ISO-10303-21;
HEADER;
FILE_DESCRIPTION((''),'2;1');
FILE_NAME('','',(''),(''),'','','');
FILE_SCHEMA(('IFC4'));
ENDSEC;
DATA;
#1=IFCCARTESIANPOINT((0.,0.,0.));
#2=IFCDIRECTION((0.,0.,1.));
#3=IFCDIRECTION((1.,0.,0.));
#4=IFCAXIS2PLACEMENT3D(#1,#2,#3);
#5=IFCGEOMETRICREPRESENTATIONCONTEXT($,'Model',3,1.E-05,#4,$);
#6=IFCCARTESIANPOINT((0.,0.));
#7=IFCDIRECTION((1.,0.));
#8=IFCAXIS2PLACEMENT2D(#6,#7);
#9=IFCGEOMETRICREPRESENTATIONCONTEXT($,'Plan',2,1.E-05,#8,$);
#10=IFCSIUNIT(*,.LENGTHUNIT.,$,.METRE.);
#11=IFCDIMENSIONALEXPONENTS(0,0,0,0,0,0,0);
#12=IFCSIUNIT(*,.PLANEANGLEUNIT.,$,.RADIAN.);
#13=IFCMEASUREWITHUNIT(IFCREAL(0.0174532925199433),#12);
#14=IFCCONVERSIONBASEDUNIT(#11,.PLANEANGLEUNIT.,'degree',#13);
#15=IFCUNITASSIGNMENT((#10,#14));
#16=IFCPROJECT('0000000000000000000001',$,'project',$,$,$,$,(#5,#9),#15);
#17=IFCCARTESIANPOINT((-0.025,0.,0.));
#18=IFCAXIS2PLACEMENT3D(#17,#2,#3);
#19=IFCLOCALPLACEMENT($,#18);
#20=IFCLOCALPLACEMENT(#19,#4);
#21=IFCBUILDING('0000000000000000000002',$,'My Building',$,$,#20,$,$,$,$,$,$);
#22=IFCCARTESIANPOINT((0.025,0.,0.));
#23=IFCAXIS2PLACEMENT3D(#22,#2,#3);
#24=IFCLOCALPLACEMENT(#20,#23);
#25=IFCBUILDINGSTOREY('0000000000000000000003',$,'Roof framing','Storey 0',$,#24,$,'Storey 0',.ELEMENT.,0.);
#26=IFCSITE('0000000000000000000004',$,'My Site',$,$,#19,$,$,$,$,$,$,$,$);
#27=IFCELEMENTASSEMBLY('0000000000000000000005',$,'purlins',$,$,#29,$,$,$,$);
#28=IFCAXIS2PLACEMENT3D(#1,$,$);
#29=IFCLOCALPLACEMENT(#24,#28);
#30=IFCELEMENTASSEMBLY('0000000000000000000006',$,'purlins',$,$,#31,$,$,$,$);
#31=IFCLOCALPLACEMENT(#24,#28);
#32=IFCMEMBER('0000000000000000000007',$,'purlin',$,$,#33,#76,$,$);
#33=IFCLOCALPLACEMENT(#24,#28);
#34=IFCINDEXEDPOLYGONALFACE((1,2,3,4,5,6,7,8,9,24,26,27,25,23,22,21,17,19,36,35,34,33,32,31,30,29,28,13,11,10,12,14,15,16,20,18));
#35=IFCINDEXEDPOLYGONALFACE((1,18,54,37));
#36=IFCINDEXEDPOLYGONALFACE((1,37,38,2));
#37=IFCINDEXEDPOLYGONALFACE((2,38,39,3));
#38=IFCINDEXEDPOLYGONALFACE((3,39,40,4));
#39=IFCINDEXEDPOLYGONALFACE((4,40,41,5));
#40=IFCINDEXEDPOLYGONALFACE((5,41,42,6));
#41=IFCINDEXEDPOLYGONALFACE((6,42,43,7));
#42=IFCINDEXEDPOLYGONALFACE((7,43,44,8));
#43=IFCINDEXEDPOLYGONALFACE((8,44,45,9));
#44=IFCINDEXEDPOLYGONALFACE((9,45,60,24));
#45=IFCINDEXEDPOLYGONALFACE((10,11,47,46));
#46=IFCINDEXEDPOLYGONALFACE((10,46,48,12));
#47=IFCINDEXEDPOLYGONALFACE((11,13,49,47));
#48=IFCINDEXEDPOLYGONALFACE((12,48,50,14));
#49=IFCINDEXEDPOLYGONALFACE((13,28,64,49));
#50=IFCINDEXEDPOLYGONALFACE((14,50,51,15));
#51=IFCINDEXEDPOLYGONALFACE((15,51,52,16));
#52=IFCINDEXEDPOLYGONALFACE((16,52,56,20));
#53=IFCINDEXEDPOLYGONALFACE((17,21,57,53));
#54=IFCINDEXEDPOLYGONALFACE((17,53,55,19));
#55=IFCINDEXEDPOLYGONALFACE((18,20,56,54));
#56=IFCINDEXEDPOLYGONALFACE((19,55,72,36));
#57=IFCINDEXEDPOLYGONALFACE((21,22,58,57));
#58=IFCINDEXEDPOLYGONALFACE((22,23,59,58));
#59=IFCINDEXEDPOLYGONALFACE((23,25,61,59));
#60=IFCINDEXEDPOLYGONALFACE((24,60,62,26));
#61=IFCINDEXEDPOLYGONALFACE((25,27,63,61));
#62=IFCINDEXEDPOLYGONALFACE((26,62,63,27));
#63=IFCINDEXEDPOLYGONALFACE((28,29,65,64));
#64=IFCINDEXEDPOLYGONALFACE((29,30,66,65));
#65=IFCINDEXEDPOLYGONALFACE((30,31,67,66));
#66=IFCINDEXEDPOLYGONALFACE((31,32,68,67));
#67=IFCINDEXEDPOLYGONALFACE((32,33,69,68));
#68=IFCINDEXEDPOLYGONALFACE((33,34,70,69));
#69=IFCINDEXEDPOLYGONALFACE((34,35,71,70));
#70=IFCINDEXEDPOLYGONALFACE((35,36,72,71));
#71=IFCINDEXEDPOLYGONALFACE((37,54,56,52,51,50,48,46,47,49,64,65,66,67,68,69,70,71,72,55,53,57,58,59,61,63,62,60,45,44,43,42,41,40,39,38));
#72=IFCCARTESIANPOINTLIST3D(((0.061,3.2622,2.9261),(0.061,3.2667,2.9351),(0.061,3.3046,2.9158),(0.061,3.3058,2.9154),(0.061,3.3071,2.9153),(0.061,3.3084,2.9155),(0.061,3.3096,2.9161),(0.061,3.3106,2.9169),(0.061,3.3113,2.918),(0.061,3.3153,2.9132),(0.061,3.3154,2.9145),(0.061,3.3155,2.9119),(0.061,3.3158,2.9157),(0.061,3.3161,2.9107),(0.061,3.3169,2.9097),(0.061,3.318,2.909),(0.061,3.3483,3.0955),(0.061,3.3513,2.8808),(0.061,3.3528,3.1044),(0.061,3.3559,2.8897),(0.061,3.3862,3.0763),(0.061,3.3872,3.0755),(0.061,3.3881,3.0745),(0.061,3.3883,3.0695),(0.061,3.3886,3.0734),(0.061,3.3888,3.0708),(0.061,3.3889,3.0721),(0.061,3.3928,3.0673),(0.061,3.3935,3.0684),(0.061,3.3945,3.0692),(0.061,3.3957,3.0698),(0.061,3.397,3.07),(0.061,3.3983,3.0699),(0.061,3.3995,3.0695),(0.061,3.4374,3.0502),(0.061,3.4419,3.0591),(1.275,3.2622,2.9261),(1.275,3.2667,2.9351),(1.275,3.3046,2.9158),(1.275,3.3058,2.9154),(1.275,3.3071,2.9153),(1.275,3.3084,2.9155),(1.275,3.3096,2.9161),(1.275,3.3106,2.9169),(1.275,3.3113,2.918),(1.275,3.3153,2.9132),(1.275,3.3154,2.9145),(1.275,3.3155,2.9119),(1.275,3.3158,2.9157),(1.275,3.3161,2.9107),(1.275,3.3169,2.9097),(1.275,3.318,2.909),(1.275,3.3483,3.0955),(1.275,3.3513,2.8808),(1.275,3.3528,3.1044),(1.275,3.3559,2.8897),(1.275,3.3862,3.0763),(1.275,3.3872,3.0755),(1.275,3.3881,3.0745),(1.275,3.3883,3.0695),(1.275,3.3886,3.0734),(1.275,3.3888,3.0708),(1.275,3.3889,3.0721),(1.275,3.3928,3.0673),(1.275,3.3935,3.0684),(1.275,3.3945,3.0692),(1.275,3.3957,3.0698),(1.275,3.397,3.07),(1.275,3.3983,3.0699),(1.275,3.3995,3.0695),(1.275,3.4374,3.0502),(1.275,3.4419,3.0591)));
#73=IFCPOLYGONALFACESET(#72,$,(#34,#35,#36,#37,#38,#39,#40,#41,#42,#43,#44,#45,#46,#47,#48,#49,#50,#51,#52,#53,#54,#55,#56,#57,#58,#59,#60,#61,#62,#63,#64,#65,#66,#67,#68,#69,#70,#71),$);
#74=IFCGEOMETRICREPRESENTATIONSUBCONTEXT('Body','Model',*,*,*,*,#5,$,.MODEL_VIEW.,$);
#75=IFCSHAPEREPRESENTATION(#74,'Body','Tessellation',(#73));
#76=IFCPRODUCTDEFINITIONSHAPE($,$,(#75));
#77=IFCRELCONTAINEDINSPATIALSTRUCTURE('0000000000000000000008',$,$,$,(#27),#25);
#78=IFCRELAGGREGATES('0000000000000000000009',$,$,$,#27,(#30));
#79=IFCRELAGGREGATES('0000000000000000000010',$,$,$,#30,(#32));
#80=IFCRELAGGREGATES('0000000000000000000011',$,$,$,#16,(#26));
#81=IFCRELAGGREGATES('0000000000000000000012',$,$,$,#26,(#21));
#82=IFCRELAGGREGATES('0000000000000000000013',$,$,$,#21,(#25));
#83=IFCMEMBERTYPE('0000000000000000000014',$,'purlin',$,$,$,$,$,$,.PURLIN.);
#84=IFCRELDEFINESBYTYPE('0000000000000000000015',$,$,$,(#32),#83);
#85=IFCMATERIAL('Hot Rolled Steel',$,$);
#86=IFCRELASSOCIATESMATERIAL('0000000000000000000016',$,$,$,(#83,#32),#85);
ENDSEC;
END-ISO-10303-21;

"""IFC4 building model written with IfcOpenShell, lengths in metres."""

from ifc_helpers import new_model, entity, si_unit, converted_unit, frame, frame_2d, origin_with_axes, origin_2d_with_axis, place, context, subcontext, project, spatial, i_section, extrude, material, material_profile, profile_set, profile_usage, type_object, element, aggregate, save


model = new_model("IFC4")

# Units and contexts
model_context = context("Model", 3, precision=1e-05, world=origin_with_axes())
plan_context = context("Plan", 2, precision=1e-05, world=origin_2d_with_axis())
body_context = subcontext(model_context, "Body", "Model", "MODEL_VIEW")
ifc_project = project(units=[si_unit("LENGTHUNIT", "METRE"), converted_unit("PLANEANGLEUNIT", "degree", entity("IfcReal", 0.0174532925199433), si_unit("PLANEANGLEUNIT", "RADIAN"), dimensions=[0, 0, 0, 0, 0, 0, 0])], contexts=[model_context, plan_context])

# Site, building, storey
site_placement = place(None, frame((-0.025, 0.0, 0.0), z_axis=(0.0, 0.0, 1.0), x_axis=(1.0, 0.0, 0.0)))
site = spatial("IfcSite", under=ifc_project, at=site_placement, Name="My Site")
building_placement = place(site_placement, origin_with_axes())
building = spatial("IfcBuilding", under=site, at=building_placement, Name="My Building")
storey_placement = place(building_placement, frame((0.025, 0.0, 0.0), z_axis=(0.0, 0.0, 1.0), x_axis=(1.0, 0.0, 0.0)))
storey = spatial("IfcBuildingStorey", under=building, at=storey_placement, Name="Roof framing", Description="Storey 0", LongName="Storey 0", CompositionType="ELEMENT", Elevation=0.0)

# Element assemblies, member
assembly_1_placement = place(storey_placement, origin_with_axes())
assembly_1 = element("IfcElementAssembly", 1, at=assembly_1_placement, inside=storey, Name="purlins")
assembly_2_placement = place(assembly_1_placement, frame((1.275, 5.07, 2.4), z_axis=(0.0, 0.453057, 0.891482), x_axis=(-1.0, 0.0, 0.0)))
assembly_2 = element("IfcElementAssembly", 2, at=assembly_2_placement, Name="purlins")
aggregate(assembly_1, [assembly_2])
ifc_material_1 = material(Name="Hot Rolled Steel")
ifc_material_profile_1 = material_profile(ifc_material_1, i_section(OverallWidth=0.1, OverallDepth=0.2, WebThickness=0.005, FlangeThickness=0.01, FilletRadius=0.005, at=frame_2d((0.0, -0.25), x_axis=(1.0, 0.0))))
ifc_profile_set_1 = profile_set([ifc_material_profile_1])
ifc_profile_usage_1 = profile_usage(ifc_profile_set_1)
member_type_1 = type_object("IfcMemberType", Name="purlin", PredefinedType="PURLIN", material=ifc_profile_set_1)
member_1_placement = place(assembly_2_placement, frame((1.214, 1.8, 0.0), z_axis=(-1.0, 0.0, 0.0), x_axis=(0.0, -1.0, 0.0)))
member_1 = element("IfcMember", 3, at=member_1_placement, type_object=member_type_1, material=ifc_profile_usage_1, Name="purlin", context=body_context, shape_type="SweptSolid", body=[
    extrude(i_section(OverallWidth=0.1, OverallDepth=0.2, WebThickness=0.005, FlangeThickness=0.01, FilletRadius=0.005, at=frame_2d((0.0, -0.25), x_axis=(1.0, 0.0))), origin_with_axes(), (0.0, 0.0, 1.0), 1.214),
])
aggregate(assembly_2, [member_1])

save(model, "model.ifc")
